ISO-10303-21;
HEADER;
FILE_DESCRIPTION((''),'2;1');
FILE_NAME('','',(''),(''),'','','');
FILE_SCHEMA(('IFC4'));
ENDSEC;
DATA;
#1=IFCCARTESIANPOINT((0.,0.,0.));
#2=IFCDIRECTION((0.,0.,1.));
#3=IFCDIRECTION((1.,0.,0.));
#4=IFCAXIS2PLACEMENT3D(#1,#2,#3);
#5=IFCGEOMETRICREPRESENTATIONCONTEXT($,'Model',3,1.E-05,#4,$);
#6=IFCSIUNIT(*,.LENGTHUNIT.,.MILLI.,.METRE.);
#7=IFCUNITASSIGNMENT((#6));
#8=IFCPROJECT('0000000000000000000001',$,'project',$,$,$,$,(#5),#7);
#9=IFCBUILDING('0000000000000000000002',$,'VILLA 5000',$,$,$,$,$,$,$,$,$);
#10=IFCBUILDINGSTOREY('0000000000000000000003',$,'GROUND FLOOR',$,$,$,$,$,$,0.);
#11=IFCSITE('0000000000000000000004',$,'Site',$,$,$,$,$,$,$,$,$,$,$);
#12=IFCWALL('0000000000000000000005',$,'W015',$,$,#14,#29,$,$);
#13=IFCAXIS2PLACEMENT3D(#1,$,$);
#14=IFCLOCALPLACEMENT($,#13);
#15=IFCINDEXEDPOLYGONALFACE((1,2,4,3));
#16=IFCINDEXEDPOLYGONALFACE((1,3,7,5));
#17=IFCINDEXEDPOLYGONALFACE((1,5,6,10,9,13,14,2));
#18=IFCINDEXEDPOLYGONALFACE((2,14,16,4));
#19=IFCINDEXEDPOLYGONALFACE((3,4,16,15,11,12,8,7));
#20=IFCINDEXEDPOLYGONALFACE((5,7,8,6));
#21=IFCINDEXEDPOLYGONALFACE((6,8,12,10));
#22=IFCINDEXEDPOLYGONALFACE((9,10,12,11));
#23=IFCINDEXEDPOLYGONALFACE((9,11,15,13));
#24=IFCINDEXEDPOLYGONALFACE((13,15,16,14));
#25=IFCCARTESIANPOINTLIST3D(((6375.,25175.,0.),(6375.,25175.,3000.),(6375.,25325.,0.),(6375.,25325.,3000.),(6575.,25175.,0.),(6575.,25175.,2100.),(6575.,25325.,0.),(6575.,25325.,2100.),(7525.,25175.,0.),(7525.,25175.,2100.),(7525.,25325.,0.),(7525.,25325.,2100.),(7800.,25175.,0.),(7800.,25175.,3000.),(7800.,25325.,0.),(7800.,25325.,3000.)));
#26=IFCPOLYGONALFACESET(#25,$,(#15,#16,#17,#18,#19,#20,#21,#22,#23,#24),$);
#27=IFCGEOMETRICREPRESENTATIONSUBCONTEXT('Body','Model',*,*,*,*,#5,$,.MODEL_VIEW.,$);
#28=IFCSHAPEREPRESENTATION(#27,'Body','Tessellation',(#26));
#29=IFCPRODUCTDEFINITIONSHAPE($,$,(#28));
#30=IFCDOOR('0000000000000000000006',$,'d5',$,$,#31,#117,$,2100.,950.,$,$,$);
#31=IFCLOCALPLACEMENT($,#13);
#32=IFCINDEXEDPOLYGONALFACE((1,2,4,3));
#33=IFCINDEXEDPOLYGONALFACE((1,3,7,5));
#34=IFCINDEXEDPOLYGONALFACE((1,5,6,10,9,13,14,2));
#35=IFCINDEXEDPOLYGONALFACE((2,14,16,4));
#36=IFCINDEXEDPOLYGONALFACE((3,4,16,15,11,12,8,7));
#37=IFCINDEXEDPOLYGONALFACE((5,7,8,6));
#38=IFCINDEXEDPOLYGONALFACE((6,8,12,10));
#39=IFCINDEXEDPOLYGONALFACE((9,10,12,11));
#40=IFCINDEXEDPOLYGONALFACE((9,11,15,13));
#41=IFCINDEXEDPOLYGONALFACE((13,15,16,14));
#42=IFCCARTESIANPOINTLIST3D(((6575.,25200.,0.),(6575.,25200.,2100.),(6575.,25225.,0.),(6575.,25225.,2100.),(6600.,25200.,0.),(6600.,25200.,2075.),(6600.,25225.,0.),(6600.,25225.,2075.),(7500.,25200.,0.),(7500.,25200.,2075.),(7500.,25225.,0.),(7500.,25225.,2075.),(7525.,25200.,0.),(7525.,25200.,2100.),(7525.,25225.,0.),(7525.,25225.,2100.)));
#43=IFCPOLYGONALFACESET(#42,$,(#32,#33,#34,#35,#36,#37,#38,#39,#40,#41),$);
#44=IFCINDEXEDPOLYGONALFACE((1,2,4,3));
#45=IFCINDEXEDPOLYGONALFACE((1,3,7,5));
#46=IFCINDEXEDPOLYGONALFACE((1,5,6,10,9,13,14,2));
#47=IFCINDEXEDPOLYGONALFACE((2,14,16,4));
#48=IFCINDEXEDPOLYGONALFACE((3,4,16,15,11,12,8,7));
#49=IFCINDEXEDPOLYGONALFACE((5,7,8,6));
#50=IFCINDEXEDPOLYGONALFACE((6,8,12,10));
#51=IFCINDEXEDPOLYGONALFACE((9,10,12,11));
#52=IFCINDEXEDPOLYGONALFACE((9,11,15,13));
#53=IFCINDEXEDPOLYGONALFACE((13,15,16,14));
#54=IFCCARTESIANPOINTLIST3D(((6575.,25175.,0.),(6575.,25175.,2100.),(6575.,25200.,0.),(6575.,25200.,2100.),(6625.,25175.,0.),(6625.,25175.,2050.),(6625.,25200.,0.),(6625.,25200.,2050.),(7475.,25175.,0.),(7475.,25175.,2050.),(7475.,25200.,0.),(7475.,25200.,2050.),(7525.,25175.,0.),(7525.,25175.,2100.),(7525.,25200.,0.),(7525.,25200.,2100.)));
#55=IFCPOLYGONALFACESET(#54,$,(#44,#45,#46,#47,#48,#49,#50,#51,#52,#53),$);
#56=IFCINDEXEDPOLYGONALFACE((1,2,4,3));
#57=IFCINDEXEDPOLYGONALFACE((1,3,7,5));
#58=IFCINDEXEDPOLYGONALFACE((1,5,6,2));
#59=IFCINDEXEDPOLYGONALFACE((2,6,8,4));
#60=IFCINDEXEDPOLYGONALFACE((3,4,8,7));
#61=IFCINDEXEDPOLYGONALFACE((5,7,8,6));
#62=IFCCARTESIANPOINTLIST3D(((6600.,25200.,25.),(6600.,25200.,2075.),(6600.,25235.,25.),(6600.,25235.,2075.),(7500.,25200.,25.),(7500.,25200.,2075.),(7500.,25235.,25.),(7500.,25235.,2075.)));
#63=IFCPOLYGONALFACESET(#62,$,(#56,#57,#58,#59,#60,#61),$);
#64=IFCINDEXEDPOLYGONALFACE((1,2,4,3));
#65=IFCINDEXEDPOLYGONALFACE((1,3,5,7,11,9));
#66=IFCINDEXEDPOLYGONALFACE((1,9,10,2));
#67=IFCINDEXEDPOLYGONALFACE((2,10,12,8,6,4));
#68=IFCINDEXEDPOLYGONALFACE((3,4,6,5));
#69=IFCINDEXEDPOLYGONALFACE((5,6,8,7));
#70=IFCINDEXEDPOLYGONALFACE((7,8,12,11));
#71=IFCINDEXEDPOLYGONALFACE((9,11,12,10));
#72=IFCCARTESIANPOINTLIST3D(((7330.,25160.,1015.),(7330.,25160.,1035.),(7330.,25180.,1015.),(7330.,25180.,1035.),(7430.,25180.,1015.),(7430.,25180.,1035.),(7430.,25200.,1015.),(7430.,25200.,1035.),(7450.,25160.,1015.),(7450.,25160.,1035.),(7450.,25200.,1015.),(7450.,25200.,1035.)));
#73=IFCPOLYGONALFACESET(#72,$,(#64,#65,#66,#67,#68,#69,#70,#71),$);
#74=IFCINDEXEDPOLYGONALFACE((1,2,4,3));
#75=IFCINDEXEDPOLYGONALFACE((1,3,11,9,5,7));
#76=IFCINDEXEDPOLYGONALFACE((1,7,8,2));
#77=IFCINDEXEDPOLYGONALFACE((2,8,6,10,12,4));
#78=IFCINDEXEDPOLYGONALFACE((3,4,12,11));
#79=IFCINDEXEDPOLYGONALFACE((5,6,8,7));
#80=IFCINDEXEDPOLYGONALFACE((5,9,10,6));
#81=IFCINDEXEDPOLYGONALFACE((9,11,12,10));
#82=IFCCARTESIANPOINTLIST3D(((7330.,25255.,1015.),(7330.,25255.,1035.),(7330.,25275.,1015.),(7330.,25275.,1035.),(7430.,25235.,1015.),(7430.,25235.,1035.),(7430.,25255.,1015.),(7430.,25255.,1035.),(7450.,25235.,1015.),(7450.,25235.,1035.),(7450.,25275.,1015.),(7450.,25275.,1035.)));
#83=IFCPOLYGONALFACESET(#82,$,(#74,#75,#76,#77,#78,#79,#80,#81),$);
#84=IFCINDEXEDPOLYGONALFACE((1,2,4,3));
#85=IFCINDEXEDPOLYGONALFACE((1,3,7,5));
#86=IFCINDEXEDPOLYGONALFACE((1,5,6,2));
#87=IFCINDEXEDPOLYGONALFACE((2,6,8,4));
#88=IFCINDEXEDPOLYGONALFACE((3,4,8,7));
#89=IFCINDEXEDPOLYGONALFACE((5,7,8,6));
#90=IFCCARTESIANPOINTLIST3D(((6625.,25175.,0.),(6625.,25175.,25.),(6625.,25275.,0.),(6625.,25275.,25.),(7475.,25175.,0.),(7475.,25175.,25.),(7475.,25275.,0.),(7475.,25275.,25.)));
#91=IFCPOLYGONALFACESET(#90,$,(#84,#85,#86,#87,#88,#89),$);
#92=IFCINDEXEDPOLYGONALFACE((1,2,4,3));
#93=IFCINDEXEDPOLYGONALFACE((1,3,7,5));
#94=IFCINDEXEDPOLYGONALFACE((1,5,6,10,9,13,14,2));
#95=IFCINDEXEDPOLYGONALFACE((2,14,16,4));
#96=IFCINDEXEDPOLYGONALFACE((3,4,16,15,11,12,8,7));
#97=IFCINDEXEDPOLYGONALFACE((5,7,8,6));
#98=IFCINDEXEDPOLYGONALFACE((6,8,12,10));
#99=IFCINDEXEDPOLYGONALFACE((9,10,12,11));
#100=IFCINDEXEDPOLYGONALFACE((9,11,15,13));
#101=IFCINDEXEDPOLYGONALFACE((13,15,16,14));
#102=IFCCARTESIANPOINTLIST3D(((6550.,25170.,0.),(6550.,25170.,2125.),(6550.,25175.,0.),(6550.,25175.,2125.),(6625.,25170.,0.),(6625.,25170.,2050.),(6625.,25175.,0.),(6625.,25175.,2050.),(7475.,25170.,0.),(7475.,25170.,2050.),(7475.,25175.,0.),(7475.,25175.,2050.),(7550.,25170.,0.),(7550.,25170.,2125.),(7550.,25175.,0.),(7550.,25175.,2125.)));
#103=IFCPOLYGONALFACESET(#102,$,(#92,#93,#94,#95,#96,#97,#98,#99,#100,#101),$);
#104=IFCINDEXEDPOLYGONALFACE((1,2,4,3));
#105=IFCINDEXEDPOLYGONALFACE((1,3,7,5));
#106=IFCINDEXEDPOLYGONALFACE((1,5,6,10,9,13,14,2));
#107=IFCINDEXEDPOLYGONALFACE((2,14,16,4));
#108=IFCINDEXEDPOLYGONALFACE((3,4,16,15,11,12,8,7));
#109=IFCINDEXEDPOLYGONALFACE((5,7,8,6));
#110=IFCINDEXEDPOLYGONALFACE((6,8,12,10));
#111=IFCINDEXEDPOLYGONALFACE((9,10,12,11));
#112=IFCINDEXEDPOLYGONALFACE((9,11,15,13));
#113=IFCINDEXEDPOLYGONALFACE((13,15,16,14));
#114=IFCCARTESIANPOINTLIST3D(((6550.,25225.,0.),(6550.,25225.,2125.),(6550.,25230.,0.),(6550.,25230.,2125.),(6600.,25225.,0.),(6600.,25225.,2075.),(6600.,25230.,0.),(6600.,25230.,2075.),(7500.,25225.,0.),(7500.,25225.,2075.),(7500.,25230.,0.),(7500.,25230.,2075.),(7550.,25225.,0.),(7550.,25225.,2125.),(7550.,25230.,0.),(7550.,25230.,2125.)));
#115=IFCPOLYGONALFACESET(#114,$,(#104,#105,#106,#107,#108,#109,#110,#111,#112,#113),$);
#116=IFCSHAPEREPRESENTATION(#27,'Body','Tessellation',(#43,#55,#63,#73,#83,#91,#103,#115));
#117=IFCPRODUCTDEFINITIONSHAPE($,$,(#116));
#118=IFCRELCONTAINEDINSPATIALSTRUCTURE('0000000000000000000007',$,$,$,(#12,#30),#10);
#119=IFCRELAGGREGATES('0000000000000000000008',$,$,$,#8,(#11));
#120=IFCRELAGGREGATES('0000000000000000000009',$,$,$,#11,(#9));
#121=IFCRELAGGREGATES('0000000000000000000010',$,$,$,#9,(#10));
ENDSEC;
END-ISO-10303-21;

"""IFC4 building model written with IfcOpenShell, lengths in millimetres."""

from ifc_helpers import new_model, si_unit, frame, origin_with_axes, place, context, subcontext, project, spatial, line, indexed_curve, outline, extrude, element, fill, save


model = new_model("IFC4")

# Units and contexts
model_context = context("Model", 3, precision=1e-05, world=origin_with_axes())
body_context = subcontext(model_context, "Body", "Model", "MODEL_VIEW")
ifc_project = project(units=[si_unit("LENGTHUNIT", "METRE", prefix="MILLI")], contexts=[model_context])

# Site, building, storey
site = spatial("IfcSite", under=ifc_project, Name="Site")
building = spatial("IfcBuilding", under=site, Name="VILLA 5000")
storey = spatial("IfcBuildingStorey", under=building, Name="GROUND FLOOR", Elevation=0.0)

# Wall, opening, door
wall_1_placement = place(None, frame((6375.0, 25250.0, 0.0), z_axis=(0.0, 0.0, 1.0), x_axis=(1.0, 0.0, 0.0)))
wall_1 = element("IfcWall", 1, at=wall_1_placement, inside=storey, Name="W015", context=body_context, shape_type="SweptSolid", body=[
    extrude(outline(indexed_curve([(0.0, 0.0), (0.0, 150.0), (1425.0, 150.0), (1425.0, 0.0), (0.0, 0.0)], self_intersect=False)), frame((0.0, -75.0, 0.0), z_axis=(0.0, 0.0, 1.0), x_axis=(1.0, 0.0, 0.0)), (0.0, 0.0, 1.0), 3000.0),
])
opening_1_placement = place(wall_1_placement, frame((200.0, 0.0, 0.0), z_axis=(0.0, 0.0, 1.0), x_axis=(1.0, 0.0, 0.0)))
opening_1 = element("IfcOpeningElement", 2, at=opening_1_placement, cuts=wall_1, context=body_context, shape_type="SweptSolid", body=[
    extrude(outline(indexed_curve([(0.0, 0.0), (0.0, 250.0), (950.0, 250.0), (950.0, 0.0), (0.0, 0.0)], self_intersect=False)), frame((0.0, -125.0, 0.0), z_axis=(0.0, 0.0, 1.0), x_axis=(1.0, 0.0, 0.0)), (0.0, 0.0, 1.0), 2100.0),
])
door_1_placement = place(None, frame((6575.0, 25175.0, 0.0), z_axis=(0.0, 0.0, 1.0), x_axis=(1.0, 0.0, 0.0)))
door_1 = element("IfcDoor", 3, at=door_1_placement, inside=storey, Name="d5", OverallHeight=2100.0, OverallWidth=950.0, context=body_context, shape_type="SweptSolid", body=[
    extrude(outline(indexed_curve([(0.0, 0.0), (0.0, 2100.0), (950.0, 2100.0), (950.0, 0.0), (925.0, 0.0), (925.0, 2075.0), (25.0, 2075.0), (25.0, 0.0)], segments=[line(1, 2, 3, 4, 5, 6, 7, 8, 1)])), frame((0.0, 25.0, 0.0), z_axis=(0.0, -1.0, 0.0), x_axis=(1.0, 0.0, 0.0)), (0.0, 0.0, -1.0), 25.0),
    extrude(outline(indexed_curve([(0.0, 0.0), (0.0, 2100.0), (950.0, 2100.0), (950.0, 0.0), (900.0, 0.0), (900.0, 2050.0), (50.0, 2050.0), (50.0, 0.0)], segments=[line(1, 2, 3, 4, 5, 6, 7, 8, 1)])), frame((0.0, 0.0, 0.0), z_axis=(0.0, -1.0, 0.0), x_axis=(1.0, 0.0, 0.0)), (0.0, 0.0, -1.0), 25.0),
    extrude(outline(indexed_curve([(0.0, 0.0), (900.0, 0.0), (900.0, 35.0), (0.0, 35.0)], segments=[line(1, 2, 3, 4, 1)])), frame((25.0, 25.0, 25.0), z_axis=(0.0, 0.0, 1.0), x_axis=(1.0, 0.0, 0.0)), (0.0, 0.0, 1.0), 2050.0),
    extrude(outline(indexed_curve([(0.0, 0.0), (0.0, -40.0), (-120.0, -40.0), (-120.0, -20.0), (-20.0, -20.0), (-20.0, 0.0)], segments=[line(1, 2, 3, 4, 5, 6, 1)])), frame((875.0, 25.0, 1015.0), z_axis=(0.0, 0.0, 1.0), x_axis=(1.0, 0.0, 0.0)), (0.0, 0.0, 1.0), 20.0),
    extrude(outline(indexed_curve([(0.0, 0.0), (0.0, 40.0), (-120.0, 40.0), (-120.0, 20.0), (-20.0, 20.0), (-20.0, 0.0)], segments=[line(1, 2, 3, 4, 5, 6, 1)])), frame((875.0, 60.0, 1015.0), z_axis=(0.0, 0.0, 1.0), x_axis=(1.0, 0.0, 0.0)), (0.0, 0.0, 1.0), 20.0),
    extrude(outline(indexed_curve([(0.0, 0.0), (850.0, 0.0), (850.0, 100.0), (0.0, 100.0)], segments=[line(1, 2, 3, 4, 1)])), frame((50.0, 0.0, 0.0), z_axis=(0.0, 0.0, 1.0), x_axis=(1.0, 0.0, 0.0)), (0.0, 0.0, 1.0), 25.0),
    extrude(outline(indexed_curve([(0.0, 0.0), (0.0, 2125.0), (1000.0, 2125.0), (1000.0, 0.0), (925.0, 0.0), (925.0, 2050.0), (75.0, 2050.0), (75.0, 0.0)], segments=[line(1, 2, 3, 4, 5, 6, 7, 8, 1)])), frame((-25.0, -5.0, 0.0), z_axis=(0.0, -1.0, 0.0), x_axis=(1.0, 0.0, 0.0)), (0.0, 0.0, -1.0), 5.0),
    extrude(outline(indexed_curve([(0.0, 0.0), (0.0, 2125.0), (1000.0, 2125.0), (1000.0, 0.0), (950.0, 0.0), (950.0, 2075.0), (50.0, 2075.0), (50.0, 0.0)], segments=[line(1, 2, 3, 4, 5, 6, 7, 8, 1)])), frame((-25.0, 50.0, 0.0), z_axis=(0.0, -1.0, 0.0), x_axis=(1.0, 0.0, 0.0)), (0.0, 0.0, -1.0), 5.0),
])
fill(opening_1, door_1)

save(model, "model.ifc")
